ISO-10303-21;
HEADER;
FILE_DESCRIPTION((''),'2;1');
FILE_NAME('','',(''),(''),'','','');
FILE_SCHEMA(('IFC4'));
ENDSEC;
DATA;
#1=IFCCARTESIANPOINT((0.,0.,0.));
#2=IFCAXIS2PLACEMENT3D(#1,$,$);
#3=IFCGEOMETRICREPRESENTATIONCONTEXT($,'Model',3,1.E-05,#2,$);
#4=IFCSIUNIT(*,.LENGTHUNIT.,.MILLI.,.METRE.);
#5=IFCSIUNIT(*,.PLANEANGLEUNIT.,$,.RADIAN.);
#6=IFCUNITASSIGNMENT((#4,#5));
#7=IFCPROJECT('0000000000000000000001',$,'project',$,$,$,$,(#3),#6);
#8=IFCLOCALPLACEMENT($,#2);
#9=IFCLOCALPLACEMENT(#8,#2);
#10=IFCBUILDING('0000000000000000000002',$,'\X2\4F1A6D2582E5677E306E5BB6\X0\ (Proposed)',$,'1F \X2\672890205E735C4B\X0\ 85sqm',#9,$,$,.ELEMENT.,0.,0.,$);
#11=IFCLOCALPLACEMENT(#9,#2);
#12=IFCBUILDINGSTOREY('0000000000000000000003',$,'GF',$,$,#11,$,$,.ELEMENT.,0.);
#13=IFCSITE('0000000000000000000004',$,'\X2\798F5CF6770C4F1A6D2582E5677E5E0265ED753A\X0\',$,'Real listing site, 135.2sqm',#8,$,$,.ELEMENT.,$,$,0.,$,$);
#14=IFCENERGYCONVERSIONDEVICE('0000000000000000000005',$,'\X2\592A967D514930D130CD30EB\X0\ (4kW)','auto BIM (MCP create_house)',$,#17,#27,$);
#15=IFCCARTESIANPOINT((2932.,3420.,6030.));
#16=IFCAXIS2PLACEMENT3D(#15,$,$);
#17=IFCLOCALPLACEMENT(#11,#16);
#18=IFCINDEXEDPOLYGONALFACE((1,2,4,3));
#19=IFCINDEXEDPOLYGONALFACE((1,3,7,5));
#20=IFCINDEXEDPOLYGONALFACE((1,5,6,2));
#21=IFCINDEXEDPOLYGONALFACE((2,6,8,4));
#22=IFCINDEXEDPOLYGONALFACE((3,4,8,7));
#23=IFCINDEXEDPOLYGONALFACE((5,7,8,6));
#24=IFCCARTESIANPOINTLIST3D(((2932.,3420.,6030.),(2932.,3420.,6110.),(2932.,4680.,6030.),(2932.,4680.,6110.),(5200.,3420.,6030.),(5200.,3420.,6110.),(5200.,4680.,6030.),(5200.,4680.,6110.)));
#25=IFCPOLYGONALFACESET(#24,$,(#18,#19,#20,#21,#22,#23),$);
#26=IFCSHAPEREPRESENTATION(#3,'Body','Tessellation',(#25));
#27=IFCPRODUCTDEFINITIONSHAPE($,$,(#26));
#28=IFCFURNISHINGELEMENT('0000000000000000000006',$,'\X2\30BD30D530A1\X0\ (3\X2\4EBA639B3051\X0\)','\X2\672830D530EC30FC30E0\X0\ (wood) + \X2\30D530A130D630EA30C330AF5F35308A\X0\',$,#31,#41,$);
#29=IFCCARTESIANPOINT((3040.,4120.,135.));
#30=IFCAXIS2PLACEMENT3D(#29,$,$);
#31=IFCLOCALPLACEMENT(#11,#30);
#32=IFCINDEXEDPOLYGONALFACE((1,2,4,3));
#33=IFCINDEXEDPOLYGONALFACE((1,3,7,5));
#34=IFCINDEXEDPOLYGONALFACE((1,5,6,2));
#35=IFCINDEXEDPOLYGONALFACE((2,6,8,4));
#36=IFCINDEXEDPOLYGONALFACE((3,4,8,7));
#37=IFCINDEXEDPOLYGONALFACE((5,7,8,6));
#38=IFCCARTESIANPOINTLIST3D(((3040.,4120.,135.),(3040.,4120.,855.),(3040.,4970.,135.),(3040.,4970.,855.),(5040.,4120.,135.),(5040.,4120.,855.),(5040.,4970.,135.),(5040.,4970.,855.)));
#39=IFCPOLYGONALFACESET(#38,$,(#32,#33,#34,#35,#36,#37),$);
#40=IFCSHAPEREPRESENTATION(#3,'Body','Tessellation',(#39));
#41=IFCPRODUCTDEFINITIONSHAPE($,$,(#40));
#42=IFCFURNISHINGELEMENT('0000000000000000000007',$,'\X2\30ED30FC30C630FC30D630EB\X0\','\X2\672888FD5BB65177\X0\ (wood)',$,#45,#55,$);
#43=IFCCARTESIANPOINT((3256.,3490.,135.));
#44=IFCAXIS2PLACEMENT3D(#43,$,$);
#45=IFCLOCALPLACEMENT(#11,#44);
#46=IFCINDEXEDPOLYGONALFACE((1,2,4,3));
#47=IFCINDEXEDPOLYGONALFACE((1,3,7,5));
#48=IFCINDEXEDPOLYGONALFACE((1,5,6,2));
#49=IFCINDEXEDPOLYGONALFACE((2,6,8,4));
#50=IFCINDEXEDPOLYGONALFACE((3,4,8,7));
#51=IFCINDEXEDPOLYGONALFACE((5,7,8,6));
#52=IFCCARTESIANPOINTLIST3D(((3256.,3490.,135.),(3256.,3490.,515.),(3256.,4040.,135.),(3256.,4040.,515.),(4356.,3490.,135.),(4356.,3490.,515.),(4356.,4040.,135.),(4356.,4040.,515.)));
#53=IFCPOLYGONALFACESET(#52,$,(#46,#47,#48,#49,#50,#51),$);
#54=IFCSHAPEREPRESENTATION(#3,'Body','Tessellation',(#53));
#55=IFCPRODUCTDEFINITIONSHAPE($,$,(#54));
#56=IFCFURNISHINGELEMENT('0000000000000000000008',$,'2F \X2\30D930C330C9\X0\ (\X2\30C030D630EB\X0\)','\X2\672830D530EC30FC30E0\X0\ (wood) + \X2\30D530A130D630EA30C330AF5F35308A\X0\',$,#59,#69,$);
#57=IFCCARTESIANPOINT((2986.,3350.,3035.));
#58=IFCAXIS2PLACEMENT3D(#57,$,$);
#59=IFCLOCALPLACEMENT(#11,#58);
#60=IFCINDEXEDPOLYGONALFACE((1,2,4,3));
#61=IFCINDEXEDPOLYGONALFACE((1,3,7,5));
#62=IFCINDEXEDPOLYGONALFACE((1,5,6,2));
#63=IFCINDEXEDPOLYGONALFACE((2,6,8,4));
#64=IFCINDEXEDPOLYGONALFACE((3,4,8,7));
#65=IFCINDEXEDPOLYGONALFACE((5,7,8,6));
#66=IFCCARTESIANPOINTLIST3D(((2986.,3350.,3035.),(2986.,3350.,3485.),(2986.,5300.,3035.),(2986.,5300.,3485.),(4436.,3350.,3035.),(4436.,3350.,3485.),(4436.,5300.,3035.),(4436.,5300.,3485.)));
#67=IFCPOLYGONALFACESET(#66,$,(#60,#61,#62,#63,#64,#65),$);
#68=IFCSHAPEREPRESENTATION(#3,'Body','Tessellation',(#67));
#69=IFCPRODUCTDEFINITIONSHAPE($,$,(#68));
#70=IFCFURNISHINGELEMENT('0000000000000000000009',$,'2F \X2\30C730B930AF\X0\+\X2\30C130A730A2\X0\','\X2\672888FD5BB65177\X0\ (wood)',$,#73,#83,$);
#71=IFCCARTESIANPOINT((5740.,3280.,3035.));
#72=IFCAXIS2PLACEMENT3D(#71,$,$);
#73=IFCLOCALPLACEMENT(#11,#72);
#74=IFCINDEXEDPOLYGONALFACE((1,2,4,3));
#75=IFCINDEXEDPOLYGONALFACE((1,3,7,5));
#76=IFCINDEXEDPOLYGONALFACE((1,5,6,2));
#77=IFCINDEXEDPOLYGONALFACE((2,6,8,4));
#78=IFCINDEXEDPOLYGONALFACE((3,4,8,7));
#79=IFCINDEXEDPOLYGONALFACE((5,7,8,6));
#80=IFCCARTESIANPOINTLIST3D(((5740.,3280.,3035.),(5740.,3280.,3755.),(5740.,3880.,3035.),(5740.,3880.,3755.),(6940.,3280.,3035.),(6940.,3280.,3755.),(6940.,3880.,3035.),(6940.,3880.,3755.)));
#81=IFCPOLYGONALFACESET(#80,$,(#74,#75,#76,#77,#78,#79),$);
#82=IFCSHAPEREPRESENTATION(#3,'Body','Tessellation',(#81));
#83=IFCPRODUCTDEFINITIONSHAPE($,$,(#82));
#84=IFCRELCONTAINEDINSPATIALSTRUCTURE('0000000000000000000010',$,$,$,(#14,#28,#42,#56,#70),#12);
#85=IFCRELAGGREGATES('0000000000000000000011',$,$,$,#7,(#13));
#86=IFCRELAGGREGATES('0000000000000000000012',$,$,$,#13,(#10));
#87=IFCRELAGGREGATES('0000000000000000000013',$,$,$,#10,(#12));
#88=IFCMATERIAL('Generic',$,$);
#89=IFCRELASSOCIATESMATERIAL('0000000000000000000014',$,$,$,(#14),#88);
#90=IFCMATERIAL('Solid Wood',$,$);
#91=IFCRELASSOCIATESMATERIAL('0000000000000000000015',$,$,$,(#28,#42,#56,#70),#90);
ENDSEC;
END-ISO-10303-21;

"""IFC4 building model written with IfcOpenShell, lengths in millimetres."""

from ifc_helpers import new_model, si_unit, frame, frame_2d, origin, place, context, project, spatial, rectangle, extrude, material, element, save


model = new_model("IFC4")

# Units and contexts
model_context = context("Model", 3, precision=1e-05, world=origin())
ifc_project = project(units=[si_unit("LENGTHUNIT", "METRE", prefix="MILLI"), si_unit("PLANEANGLEUNIT", "RADIAN")], contexts=[model_context])

# Site, building, storey
site_placement = place(None, origin())
site = spatial("IfcSite", under=ifc_project, at=site_placement, Name="福島県会津若松市旭町", ObjectType="Real listing site, 135.2sqm", CompositionType="ELEMENT", RefElevation=0.0)
building_placement = place(site_placement, origin())
building = spatial("IfcBuilding", under=site, at=building_placement, Name="会津若松の家 (Proposed)", ObjectType="1F 木造平屋 85sqm", CompositionType="ELEMENT", ElevationOfRefHeight=0.0, ElevationOfTerrain=0.0)
storey_placement = place(building_placement, origin())
storey = spatial("IfcBuildingStorey", under=building, at=storey_placement, Name="GF", CompositionType="ELEMENT", Elevation=0.0)

# Shared definitions
ifc_material_1 = material(Name="Solid Wood")

# Shared definitions
ifc_material_2 = material(Name="Generic")

# Energy conversion device
energy_conversion_device_placement = place(storey_placement, frame((2932.0, 3420.0, 6030.0)))
element("IfcEnergyConversionDevice", 1, at=energy_conversion_device_placement, inside=storey, material=ifc_material_2, Name="太陽光パネル (4kW)", Description="auto BIM (MCP create_house)", context=model_context, shape_type="SweptSolid", body=[
    extrude(rectangle(XDim=2268.0, YDim=1260.0, at=frame_2d((1134.0, 630.0))), frame((2932.0, 3420.0, 6030.0)), (0.0, 0.0, 1.0), 80.0),
])

# Furnishing elements
furnishing_1_placement = place(storey_placement, frame((3040.0, 4120.0, 135.0)))
element("IfcFurnishingElement", 2, at=furnishing_1_placement, inside=storey, material=ifc_material_1, Name="ソファ (3人掛け)", Description="木フレーム (wood) + ファブリック張り", context=model_context, shape_type="SweptSolid", body=[
    extrude(rectangle(XDim=2000.0, YDim=850.0, at=frame_2d((1000.0, 425.0))), frame((3040.0, 4120.0, 135.0)), (0.0, 0.0, 1.0), 720.0),
])
furnishing_2_placement = place(storey_placement, frame((3256.0, 3490.0, 135.0)))
element("IfcFurnishingElement", 3, at=furnishing_2_placement, inside=storey, material=ifc_material_1, Name="ローテーブル", Description="木製家具 (wood)", context=model_context, shape_type="SweptSolid", body=[
    extrude(rectangle(XDim=1100.0, YDim=550.0, at=frame_2d((550.0, 275.0))), frame((3256.0, 3490.0, 135.0)), (0.0, 0.0, 1.0), 380.0),
])
furnishing_3_placement = place(storey_placement, frame((2986.0, 3350.0, 3035.0)))
element("IfcFurnishingElement", 4, at=furnishing_3_placement, inside=storey, material=ifc_material_1, Name="2F ベッド (ダブル)", Description="木フレーム (wood) + ファブリック張り", context=model_context, shape_type="SweptSolid", body=[
    extrude(rectangle(XDim=1450.0, YDim=1950.0, at=frame_2d((725.0, 975.0))), frame((2986.0, 3350.0, 3035.0)), (0.0, 0.0, 1.0), 450.0),
])
furnishing_4_placement = place(storey_placement, frame((5740.0, 3280.0, 3035.0)))
element("IfcFurnishingElement", 5, at=furnishing_4_placement, inside=storey, material=ifc_material_1, Name="2F デスク+チェア", Description="木製家具 (wood)", context=model_context, shape_type="SweptSolid", body=[
    extrude(rectangle(XDim=1200.0, YDim=600.0, at=frame_2d((600.0, 300.0))), frame((5740.0, 3280.0, 3035.0)), (0.0, 0.0, 1.0), 720.0),
])

save(model, "model.ifc")
